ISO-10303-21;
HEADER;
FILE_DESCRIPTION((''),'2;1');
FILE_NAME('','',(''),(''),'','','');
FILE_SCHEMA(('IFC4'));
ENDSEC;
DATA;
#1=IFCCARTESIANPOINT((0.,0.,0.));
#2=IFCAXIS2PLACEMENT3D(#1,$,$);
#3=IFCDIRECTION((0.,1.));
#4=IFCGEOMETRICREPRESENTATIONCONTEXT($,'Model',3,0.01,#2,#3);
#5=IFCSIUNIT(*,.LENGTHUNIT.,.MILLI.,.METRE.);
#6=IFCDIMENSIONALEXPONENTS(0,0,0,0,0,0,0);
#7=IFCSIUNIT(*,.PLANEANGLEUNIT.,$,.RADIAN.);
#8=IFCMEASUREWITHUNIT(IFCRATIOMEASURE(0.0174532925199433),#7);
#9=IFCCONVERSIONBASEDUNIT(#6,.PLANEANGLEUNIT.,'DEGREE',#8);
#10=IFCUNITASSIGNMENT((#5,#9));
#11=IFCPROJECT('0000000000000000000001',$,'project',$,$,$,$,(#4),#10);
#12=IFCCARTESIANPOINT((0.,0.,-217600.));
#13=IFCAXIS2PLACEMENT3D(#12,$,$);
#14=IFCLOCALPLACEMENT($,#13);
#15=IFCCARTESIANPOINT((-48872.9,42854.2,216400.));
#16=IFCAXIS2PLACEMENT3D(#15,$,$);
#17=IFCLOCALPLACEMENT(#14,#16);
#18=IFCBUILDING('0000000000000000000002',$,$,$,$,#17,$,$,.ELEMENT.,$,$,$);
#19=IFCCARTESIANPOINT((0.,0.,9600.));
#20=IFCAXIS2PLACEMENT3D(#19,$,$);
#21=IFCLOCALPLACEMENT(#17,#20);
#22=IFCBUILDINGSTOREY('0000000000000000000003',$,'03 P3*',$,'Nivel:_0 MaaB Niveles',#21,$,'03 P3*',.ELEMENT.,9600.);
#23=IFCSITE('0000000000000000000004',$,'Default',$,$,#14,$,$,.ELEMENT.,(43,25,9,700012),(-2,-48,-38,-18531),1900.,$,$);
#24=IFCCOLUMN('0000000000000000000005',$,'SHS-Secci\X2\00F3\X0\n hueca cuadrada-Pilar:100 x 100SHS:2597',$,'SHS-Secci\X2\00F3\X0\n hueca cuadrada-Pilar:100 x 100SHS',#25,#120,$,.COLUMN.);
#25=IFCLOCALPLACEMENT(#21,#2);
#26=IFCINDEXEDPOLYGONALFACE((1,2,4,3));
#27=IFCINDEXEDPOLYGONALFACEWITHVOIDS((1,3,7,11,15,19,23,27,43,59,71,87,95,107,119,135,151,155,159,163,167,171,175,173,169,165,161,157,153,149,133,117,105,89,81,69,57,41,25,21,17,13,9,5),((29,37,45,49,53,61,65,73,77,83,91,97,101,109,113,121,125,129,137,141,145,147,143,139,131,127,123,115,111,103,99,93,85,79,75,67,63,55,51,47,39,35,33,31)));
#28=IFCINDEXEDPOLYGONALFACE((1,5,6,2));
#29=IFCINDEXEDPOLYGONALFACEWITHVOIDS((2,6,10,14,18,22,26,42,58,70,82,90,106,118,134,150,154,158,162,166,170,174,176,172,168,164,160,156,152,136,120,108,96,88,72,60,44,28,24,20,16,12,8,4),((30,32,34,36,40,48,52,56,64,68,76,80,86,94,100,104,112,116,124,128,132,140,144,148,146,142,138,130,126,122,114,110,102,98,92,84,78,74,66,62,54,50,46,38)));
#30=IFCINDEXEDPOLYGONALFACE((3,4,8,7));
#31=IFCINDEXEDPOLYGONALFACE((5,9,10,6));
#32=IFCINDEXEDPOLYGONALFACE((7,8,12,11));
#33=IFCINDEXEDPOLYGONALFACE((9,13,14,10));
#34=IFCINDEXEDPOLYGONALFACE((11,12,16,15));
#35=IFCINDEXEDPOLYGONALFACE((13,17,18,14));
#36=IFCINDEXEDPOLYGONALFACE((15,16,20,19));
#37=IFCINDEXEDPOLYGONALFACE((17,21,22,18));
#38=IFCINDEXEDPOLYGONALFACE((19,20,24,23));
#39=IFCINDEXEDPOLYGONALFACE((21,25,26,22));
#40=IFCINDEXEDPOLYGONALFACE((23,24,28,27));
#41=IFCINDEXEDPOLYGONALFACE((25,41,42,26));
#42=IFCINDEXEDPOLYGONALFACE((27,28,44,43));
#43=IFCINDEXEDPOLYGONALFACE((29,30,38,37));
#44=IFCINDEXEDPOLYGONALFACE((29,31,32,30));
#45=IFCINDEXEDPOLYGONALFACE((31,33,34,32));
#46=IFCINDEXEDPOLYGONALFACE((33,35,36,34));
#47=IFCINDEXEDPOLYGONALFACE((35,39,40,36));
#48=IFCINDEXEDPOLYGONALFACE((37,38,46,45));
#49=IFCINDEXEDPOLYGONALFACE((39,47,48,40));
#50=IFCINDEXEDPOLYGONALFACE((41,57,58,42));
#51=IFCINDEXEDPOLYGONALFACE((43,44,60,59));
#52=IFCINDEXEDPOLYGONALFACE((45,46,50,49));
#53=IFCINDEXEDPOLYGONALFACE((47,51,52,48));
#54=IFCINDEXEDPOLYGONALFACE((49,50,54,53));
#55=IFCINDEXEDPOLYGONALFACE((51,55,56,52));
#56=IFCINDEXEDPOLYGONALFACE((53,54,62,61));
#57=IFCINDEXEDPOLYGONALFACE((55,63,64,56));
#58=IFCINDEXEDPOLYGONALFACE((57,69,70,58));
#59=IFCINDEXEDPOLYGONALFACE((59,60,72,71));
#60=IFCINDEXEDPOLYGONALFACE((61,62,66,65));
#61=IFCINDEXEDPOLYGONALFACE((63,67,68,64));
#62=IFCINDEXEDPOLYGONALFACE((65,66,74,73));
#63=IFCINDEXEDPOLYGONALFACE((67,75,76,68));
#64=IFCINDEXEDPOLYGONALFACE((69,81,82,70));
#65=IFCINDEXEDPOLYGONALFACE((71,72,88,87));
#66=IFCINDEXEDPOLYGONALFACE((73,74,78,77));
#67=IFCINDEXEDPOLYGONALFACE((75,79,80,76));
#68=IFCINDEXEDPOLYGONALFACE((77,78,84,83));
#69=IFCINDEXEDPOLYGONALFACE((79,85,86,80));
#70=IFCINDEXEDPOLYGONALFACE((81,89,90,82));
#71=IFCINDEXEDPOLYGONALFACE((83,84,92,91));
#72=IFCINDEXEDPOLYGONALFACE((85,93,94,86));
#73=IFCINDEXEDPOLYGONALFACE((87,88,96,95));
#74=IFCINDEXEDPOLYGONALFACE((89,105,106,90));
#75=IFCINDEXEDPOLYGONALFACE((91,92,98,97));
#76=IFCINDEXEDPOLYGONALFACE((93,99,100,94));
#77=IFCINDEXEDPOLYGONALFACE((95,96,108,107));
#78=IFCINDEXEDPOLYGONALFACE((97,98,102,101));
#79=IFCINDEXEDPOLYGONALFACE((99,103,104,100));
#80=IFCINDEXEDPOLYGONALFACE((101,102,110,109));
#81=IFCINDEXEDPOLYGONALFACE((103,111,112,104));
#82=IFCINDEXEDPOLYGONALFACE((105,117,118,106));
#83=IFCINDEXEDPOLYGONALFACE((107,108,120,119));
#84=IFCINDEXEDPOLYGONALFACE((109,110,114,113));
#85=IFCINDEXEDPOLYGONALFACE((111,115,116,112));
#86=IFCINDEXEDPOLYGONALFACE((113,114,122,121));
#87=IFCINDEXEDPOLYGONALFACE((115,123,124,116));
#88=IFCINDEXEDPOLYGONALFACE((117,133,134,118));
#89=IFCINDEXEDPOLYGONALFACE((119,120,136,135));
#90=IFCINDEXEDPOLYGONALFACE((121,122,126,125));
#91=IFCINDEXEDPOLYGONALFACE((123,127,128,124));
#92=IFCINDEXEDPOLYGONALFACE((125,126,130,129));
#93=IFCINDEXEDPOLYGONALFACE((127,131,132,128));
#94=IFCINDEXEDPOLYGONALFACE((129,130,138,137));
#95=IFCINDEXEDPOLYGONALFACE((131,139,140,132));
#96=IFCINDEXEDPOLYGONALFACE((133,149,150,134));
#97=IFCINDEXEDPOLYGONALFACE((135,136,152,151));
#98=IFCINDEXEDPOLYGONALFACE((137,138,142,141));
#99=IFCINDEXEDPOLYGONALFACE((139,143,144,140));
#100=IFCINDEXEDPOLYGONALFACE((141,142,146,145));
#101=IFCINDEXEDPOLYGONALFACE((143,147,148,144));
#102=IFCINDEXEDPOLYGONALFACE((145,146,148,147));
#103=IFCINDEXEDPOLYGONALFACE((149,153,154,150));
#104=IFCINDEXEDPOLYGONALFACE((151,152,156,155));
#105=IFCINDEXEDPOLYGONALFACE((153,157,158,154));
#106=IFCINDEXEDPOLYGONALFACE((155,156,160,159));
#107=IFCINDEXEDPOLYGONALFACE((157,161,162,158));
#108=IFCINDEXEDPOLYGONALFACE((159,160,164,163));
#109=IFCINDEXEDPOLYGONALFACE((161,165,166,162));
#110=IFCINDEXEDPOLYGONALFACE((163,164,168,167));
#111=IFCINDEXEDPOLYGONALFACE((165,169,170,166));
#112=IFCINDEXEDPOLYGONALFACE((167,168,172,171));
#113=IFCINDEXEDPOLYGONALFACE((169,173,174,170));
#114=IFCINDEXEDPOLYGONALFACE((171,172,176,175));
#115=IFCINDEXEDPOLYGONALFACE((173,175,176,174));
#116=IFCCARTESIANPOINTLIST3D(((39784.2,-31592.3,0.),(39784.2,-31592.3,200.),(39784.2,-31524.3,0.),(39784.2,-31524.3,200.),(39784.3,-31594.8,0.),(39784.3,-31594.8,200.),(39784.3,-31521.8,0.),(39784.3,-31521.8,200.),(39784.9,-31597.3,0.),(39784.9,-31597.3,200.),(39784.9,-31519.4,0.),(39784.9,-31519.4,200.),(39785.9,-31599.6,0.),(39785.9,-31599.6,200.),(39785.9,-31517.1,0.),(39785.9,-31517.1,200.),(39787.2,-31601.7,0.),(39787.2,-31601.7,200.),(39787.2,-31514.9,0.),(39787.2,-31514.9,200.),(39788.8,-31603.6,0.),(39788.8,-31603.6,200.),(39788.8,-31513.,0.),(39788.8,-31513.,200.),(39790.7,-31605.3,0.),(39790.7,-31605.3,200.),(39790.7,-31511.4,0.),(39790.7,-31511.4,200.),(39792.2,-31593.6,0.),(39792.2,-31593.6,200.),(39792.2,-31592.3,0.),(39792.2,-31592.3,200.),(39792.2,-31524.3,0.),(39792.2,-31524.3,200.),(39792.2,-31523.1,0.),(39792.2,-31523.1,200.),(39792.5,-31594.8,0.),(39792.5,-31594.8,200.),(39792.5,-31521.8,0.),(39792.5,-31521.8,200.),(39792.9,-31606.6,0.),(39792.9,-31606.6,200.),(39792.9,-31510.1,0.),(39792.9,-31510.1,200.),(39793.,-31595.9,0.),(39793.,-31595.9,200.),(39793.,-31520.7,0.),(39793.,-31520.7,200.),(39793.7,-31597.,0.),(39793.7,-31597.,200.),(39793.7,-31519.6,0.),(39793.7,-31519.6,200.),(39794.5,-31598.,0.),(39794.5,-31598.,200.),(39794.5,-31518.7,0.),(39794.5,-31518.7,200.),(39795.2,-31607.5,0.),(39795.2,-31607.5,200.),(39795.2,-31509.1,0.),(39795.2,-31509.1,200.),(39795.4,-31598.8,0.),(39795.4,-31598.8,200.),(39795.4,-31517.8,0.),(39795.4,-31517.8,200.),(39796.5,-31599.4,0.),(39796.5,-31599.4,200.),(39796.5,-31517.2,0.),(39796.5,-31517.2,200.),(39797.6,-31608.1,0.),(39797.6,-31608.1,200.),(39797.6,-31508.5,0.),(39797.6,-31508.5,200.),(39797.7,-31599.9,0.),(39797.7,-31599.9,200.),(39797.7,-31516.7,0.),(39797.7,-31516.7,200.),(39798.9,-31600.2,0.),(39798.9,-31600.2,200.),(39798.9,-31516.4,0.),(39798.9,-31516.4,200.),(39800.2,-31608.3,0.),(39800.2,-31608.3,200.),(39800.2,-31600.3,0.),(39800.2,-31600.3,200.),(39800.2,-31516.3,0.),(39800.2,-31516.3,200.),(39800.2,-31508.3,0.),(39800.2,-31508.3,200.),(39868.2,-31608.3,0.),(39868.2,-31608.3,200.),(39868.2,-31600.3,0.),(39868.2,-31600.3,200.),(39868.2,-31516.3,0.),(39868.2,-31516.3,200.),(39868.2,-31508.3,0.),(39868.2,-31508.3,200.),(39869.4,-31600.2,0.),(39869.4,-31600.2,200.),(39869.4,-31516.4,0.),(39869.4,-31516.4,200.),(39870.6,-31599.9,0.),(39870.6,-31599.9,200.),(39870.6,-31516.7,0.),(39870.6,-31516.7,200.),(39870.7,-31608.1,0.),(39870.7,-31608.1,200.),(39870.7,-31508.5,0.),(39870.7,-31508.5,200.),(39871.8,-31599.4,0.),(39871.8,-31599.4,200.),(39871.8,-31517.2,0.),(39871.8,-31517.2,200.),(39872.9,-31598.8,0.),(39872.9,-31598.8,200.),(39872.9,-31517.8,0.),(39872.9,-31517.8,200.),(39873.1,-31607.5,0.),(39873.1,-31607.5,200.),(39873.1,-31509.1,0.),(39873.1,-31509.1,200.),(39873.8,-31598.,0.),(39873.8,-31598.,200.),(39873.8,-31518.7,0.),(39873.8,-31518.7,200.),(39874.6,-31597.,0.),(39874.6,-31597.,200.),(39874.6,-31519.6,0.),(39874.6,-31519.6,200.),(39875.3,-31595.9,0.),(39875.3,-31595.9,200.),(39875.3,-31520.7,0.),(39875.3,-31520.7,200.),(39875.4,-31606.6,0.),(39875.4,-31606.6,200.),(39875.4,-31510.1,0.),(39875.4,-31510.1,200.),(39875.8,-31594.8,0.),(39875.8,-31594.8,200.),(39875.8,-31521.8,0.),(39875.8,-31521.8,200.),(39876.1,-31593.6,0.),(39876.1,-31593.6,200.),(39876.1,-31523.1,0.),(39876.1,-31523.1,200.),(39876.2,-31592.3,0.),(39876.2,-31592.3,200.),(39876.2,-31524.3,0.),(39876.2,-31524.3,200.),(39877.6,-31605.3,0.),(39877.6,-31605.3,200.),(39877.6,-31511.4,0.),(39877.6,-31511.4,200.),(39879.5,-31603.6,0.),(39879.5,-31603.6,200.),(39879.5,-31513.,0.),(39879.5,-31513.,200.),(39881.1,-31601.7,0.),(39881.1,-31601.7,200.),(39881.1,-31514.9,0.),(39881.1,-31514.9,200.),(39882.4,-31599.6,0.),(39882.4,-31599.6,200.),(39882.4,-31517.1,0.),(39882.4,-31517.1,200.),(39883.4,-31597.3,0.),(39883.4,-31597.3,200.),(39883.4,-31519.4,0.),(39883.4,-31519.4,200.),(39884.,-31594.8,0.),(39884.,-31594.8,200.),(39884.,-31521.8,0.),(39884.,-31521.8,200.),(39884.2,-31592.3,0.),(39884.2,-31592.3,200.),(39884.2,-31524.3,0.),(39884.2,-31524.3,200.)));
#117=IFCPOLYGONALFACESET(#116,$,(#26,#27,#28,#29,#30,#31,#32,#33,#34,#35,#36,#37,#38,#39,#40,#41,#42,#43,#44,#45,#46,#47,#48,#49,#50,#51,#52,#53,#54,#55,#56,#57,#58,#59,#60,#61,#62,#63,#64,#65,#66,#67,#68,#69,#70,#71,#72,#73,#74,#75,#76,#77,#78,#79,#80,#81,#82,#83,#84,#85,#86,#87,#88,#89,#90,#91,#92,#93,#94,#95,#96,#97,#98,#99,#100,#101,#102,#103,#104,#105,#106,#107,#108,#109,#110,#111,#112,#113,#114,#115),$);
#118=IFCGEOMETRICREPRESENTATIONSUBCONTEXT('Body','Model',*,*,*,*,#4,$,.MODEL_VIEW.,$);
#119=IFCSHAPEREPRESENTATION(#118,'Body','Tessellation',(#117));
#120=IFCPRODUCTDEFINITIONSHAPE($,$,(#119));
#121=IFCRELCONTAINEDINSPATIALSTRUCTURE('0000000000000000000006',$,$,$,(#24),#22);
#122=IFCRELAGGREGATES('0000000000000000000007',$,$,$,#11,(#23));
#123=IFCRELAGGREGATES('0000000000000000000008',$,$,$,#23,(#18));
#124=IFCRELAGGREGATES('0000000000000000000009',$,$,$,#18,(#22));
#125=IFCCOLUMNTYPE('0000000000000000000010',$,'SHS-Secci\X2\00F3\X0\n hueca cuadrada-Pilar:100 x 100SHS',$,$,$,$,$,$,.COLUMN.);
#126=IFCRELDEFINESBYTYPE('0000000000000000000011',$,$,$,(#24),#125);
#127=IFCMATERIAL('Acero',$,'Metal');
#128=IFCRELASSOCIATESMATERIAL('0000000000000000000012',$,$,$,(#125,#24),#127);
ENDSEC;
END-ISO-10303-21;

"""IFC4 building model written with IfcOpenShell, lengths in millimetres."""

from ifc_helpers import new_model, entity, si_unit, converted_unit, direction, frame, origin, place, context, subcontext, project, spatial, indexed_curve, outline, extrude, source, transform, mapped, material, type_object, type_shapes, element, save


model = new_model("IFC4")

# Units and contexts
model_context = context("Model", 3, precision=0.01, world=origin(), true_north=direction((0.0, 1.0)))
body_context = subcontext(model_context, "Body", "Model", "MODEL_VIEW")
ifc_project = project(units=[si_unit("LENGTHUNIT", "METRE", prefix="MILLI"), converted_unit("PLANEANGLEUNIT", "DEGREE", entity("IfcRatioMeasure", 0.0174532925199433), si_unit("PLANEANGLEUNIT", "RADIAN"), dimensions=[0, 0, 0, 0, 0, 0, 0])], contexts=[model_context])

# Site, building, storey
site_placement = place(None, frame((0.0, 0.0, -217600.0)))
site = spatial("IfcSite", under=ifc_project, at=site_placement, Name="Default", CompositionType="ELEMENT", RefLatitude=(43, 25, 9, 700012), RefLongitude=(-2, -48, -38, -18531), RefElevation=1900.0)
building_placement = place(site_placement, frame((-48872.9, 42854.2, 216400.0)))
building = spatial("IfcBuilding", under=site, at=building_placement, CompositionType="ELEMENT")
storey_placement = place(building_placement, frame((0.0, 0.0, 9600.0)))
storey = spatial("IfcBuildingStorey", under=building, at=storey_placement, Name="03 P3*", ObjectType="Nivel:_0 MaaB Niveles", LongName="03 P3*", CompositionType="ELEMENT", Elevation=9600.0)

# Column
ifc_material_1 = material(Name="Acero", Category="Metal")
column_type_1 = type_object("IfcColumnType", Name="SHS-Sección hueca cuadrada-Pilar:100 x 100SHS", PredefinedType="COLUMN", material=ifc_material_1)
shared_shape_1 = source(origin(), body_context, "Body", "SweptSolid", [
    extrude(outline(indexed_curve([(-34.0, -50.0), (34.0, -50.0), (36.5, -49.8), (38.9, -49.2), (41.3, -48.3), (43.4, -46.9), (45.3, -45.3), (46.9, -43.4), (48.3, -41.3), (49.2, -38.9), (49.8, -36.5), (50.0, -34.0), (50.0, 34.0), (49.8, 36.5), (49.2, 38.9), (48.3, 41.3), (46.9, 43.4), (45.3, 45.3), (43.4, 46.9), (41.3, 48.3), (38.9, 49.2), (36.5, 49.8), (34.0, 50.0), (-34.0, 50.0), (-36.5, 49.8), (-38.9, 49.2), (-41.3, 48.3), (-43.4, 46.9), (-45.3, 45.3), (-46.9, 43.4), (-48.3, 41.3), (-49.2, 38.9), (-49.8, 36.5), (-50.0, 34.0), (-50.0, -34.0), (-49.8, -36.5), (-49.2, -38.9), (-48.3, -41.3), (-46.9, -43.4), (-45.3, -45.3), (-43.4, -46.9), (-41.3, -48.3), (-38.9, -49.2), (-36.5, -49.8), (-34.0, -50.0)], self_intersect=False), holes=[indexed_curve([(-34.0, -42.0), (-35.3, -41.9), (-36.5, -41.6), (-37.6, -41.1), (-38.7, -40.5), (-39.7, -39.7), (-40.5, -38.7), (-41.1, -37.6), (-41.6, -36.5), (-41.9, -35.3), (-42.0, -34.0), (-42.0, 34.0), (-41.9, 35.3), (-41.6, 36.5), (-41.1, 37.6), (-40.5, 38.7), (-39.7, 39.7), (-38.7, 40.5), (-37.6, 41.1), (-36.5, 41.6), (-35.3, 41.9), (-34.0, 42.0), (34.0, 42.0), (35.3, 41.9), (36.5, 41.6), (37.6, 41.1), (38.7, 40.5), (39.7, 39.7), (40.5, 38.7), (41.1, 37.6), (41.6, 36.5), (41.9, 35.3), (42.0, 34.0), (42.0, -34.0), (41.9, -35.3), (41.6, -36.5), (41.1, -37.6), (40.5, -38.7), (39.7, -39.7), (38.7, -40.5), (37.6, -41.1), (36.5, -41.6), (35.3, -41.9), (34.0, -42.0), (-34.0, -42.0)], self_intersect=False)]), frame((0.0, 0.0, 9600.0), z_axis=(0.0, 0.0, 1.0), x_axis=(-1.0, 0.0, 0.0)), (0.0, 0.0, 1.0), 200.0),
])
type_shapes(column_type_1, [shared_shape_1])
column_1_placement = place(storey_placement, frame((39834.2, -31558.3, -9600.0), z_axis=(0.0, 0.0, 1.0), x_axis=(0.0, -1.0, 0.0)))
element("IfcColumn", 1, at=column_1_placement, inside=storey, type_object=column_type_1, material=ifc_material_1, Name="SHS-Sección hueca cuadrada-Pilar:100 x 100SHS:2597", ObjectType="SHS-Sección hueca cuadrada-Pilar:100 x 100SHS", PredefinedType="COLUMN", context=body_context, shape_type="MappedRepresentation", body=[
    mapped(shared_shape_1, transform((0.0, 0.0, 0.0), scale=1.0)),
])

save(model, "model.ifc")
